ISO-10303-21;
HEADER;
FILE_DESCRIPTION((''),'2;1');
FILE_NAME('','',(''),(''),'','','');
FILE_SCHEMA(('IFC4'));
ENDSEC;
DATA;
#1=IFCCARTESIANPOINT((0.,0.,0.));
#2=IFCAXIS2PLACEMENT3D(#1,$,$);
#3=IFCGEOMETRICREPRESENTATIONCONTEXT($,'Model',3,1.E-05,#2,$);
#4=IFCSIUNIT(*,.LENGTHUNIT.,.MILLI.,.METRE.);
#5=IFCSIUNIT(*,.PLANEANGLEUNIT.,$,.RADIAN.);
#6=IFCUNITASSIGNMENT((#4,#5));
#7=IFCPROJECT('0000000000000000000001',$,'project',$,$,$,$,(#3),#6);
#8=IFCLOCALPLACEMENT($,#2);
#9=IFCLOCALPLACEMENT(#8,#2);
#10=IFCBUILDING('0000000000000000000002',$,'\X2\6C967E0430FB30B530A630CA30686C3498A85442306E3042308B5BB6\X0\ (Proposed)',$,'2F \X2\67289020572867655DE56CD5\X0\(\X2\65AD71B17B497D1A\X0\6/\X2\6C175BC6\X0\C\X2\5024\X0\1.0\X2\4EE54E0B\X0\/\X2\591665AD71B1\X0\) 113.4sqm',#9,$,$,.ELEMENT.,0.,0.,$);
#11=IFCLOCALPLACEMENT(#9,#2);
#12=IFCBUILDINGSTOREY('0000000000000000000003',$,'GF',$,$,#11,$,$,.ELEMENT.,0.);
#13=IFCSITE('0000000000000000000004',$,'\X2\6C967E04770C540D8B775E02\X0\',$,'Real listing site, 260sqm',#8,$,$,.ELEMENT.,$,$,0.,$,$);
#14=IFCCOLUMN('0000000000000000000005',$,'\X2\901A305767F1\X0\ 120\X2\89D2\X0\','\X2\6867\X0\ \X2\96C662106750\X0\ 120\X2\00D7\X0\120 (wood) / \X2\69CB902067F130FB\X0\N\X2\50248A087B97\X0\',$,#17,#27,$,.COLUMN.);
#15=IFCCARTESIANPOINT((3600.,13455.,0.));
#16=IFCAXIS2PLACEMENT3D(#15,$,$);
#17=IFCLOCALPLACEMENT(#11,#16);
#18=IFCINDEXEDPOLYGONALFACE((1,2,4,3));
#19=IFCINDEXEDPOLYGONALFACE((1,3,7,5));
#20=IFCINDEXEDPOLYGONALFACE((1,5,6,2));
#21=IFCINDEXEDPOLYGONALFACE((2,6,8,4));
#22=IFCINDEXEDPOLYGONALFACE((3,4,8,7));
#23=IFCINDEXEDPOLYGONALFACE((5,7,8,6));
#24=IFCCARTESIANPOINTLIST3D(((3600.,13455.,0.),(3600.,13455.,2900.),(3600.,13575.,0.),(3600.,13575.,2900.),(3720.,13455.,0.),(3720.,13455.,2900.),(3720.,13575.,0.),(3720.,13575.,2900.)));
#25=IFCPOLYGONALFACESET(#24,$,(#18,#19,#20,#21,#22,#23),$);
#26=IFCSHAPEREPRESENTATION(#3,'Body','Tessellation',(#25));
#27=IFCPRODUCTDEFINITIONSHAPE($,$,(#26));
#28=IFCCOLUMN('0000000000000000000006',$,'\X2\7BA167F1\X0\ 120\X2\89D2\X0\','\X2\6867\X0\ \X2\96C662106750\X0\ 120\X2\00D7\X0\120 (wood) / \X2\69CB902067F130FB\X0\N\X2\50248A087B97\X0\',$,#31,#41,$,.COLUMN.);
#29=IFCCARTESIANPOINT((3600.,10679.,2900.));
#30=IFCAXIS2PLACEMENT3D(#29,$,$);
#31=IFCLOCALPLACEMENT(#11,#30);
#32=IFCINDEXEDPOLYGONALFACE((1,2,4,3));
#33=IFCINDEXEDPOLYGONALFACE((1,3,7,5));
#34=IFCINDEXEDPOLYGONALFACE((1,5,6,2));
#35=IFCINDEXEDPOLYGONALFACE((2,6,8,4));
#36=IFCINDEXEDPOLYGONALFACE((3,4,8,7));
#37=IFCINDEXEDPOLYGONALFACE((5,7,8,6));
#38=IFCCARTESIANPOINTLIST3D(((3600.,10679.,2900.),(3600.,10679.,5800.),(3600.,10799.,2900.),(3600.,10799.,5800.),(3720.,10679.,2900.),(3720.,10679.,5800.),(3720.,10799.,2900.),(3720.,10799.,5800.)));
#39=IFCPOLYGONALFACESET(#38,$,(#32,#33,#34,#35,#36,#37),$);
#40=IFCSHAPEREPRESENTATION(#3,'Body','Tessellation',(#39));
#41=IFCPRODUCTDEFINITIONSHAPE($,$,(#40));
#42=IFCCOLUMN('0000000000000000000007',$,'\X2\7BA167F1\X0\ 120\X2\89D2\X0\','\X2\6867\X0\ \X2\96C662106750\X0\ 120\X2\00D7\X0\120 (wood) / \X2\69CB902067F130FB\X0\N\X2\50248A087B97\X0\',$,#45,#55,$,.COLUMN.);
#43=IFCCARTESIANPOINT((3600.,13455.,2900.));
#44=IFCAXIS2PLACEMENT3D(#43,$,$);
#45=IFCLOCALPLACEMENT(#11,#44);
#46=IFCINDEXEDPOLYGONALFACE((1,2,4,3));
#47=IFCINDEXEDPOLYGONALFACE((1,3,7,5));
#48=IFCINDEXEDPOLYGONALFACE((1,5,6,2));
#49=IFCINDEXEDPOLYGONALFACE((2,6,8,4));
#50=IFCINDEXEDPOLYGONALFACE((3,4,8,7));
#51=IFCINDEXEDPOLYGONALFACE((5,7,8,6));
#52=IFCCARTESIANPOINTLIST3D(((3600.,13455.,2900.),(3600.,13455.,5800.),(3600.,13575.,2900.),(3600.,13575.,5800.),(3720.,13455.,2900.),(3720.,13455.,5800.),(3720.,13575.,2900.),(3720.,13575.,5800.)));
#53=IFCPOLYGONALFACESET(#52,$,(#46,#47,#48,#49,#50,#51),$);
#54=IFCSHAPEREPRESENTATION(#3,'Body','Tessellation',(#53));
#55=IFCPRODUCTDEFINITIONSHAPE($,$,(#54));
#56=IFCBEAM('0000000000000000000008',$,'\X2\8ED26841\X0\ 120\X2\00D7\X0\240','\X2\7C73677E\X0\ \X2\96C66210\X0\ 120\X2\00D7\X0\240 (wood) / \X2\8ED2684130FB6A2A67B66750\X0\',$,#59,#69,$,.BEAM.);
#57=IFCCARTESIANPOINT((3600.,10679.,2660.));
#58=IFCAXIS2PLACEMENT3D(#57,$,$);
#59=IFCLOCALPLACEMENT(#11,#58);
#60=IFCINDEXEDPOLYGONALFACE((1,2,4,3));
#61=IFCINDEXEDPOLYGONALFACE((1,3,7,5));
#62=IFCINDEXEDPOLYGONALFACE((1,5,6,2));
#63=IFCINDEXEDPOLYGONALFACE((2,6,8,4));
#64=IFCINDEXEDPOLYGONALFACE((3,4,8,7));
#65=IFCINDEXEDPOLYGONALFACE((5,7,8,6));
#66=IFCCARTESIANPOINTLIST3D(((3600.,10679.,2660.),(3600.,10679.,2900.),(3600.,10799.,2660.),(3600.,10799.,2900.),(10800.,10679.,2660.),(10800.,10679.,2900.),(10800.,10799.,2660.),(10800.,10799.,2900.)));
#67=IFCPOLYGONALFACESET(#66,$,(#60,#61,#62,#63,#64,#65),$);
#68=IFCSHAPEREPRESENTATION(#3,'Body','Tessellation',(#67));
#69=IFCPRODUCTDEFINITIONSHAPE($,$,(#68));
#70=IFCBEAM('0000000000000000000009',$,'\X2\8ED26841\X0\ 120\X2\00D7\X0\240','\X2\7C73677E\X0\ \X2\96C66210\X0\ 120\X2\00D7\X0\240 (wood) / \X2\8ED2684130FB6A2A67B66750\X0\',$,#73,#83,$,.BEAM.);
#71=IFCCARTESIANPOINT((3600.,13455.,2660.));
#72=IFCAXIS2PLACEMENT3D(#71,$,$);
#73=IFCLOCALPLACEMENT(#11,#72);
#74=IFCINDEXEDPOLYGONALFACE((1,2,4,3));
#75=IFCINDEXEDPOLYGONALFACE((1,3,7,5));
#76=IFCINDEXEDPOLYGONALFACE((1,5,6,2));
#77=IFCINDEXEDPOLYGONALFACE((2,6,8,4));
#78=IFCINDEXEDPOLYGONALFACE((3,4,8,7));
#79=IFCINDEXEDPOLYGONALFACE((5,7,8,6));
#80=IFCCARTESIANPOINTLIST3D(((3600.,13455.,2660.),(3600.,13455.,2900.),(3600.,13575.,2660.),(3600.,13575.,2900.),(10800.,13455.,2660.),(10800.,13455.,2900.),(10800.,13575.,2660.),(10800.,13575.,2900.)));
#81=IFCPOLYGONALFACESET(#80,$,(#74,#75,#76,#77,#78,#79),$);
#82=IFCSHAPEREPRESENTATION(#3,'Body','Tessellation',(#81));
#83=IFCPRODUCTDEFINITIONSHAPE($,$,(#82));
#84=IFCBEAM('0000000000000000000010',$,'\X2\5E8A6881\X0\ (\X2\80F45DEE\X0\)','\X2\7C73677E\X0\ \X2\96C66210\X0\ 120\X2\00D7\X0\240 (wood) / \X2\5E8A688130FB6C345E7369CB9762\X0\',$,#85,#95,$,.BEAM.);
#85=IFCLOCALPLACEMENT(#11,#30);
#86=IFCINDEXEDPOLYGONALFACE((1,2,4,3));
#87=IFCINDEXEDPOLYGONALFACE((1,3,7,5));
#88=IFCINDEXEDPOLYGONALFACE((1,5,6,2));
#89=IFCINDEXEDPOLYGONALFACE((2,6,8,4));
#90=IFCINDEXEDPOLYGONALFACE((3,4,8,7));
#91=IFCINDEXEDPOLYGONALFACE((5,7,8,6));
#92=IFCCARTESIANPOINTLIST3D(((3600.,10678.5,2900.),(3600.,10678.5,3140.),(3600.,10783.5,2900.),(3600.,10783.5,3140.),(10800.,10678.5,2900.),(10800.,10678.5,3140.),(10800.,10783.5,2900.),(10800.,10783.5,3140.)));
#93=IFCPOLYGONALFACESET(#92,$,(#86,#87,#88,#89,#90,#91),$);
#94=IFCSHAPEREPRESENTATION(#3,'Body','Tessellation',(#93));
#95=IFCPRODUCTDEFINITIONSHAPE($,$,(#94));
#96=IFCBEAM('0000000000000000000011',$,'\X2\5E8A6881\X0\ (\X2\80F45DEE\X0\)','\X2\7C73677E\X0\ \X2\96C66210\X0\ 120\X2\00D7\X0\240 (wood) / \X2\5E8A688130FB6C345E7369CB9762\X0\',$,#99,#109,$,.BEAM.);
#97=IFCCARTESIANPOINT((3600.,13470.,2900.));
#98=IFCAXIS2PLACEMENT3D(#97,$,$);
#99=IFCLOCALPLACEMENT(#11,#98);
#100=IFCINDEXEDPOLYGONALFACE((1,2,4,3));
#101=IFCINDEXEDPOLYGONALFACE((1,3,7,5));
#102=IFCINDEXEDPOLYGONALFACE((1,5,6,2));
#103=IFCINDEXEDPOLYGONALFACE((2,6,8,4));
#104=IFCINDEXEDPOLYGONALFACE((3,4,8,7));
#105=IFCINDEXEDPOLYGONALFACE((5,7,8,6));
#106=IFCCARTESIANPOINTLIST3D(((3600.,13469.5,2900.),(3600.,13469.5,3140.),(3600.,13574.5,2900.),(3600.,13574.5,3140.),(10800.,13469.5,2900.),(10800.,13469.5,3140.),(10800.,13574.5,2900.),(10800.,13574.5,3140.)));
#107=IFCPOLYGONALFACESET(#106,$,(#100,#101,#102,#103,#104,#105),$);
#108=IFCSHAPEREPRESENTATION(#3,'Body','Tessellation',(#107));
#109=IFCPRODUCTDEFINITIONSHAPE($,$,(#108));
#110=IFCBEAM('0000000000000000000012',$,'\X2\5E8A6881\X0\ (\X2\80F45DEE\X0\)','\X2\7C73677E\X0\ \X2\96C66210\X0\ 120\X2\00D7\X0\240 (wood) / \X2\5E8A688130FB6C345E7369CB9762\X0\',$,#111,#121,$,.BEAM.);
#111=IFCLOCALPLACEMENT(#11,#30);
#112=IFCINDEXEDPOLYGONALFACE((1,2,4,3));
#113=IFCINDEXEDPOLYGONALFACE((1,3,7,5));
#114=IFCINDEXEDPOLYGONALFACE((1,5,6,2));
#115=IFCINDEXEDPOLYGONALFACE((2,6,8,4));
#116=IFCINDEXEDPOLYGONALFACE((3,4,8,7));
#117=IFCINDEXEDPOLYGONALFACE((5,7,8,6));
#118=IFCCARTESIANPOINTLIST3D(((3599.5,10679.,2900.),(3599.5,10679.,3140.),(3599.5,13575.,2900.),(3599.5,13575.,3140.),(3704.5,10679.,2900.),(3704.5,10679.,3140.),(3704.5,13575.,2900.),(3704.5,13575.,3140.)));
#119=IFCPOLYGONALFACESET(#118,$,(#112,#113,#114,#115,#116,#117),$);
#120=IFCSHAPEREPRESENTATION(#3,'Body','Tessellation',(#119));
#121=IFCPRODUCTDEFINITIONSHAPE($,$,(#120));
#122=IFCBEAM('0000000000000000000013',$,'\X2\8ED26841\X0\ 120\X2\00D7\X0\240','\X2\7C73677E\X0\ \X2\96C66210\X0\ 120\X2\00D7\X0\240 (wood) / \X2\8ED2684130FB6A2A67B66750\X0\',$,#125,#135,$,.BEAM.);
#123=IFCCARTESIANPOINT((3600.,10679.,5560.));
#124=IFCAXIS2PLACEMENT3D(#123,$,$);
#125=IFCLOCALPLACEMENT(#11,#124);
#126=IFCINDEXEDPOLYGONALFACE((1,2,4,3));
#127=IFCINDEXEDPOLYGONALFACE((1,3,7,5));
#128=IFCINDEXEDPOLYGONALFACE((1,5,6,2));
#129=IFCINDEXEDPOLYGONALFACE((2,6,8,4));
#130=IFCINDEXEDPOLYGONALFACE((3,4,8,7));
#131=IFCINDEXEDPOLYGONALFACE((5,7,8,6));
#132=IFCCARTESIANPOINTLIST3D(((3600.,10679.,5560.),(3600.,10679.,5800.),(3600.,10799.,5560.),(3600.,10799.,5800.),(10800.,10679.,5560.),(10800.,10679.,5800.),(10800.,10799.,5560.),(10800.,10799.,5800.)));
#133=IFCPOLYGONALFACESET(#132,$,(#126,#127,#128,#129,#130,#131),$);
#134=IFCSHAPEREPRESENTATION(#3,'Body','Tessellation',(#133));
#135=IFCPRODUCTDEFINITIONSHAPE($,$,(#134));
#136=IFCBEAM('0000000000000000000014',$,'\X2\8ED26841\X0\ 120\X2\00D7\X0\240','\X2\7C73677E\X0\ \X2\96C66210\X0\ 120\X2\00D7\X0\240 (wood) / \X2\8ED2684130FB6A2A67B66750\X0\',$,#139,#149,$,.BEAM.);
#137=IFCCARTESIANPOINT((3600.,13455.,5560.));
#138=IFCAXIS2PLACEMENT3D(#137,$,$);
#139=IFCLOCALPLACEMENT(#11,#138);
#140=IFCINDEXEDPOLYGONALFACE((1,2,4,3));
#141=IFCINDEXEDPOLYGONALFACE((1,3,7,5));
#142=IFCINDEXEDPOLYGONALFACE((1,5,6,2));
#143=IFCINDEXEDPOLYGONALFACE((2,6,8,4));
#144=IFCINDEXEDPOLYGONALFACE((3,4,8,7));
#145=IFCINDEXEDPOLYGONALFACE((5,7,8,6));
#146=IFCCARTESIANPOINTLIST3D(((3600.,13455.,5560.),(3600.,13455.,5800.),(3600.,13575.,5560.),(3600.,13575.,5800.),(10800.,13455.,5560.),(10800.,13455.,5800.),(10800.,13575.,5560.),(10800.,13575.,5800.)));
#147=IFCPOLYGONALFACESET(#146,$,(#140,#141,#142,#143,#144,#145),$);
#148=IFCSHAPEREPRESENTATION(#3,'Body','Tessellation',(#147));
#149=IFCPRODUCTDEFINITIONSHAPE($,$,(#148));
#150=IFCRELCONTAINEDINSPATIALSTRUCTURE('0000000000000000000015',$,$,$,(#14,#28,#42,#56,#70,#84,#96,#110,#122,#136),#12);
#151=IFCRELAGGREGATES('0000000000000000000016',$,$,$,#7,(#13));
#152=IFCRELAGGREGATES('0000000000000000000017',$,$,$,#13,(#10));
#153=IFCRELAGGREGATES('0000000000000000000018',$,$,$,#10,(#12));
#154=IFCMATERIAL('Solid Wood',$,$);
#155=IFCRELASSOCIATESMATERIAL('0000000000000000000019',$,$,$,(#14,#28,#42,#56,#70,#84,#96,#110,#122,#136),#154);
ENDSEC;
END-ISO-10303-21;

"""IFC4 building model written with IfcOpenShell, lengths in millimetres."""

from ifc_helpers import new_model, si_unit, frame, frame_2d, origin, place, context, project, spatial, rectangle, extrude, material, element, save


model = new_model("IFC4")

# Units and contexts
model_context = context("Model", 3, precision=1e-05, world=origin())
ifc_project = project(units=[si_unit("LENGTHUNIT", "METRE", prefix="MILLI"), si_unit("PLANEANGLEUNIT", "RADIAN")], contexts=[model_context])

# Site, building, storey
site_placement = place(None, origin())
site = spatial("IfcSite", under=ifc_project, at=site_placement, Name="沖縄県名護市", ObjectType="Real listing site, 260sqm", CompositionType="ELEMENT", RefElevation=0.0)
building_placement = place(site_placement, origin())
building = spatial("IfcBuilding", under=site, at=building_placement, Name="沖縄・サウナと水風呂のある家 (Proposed)", ObjectType="2F 木造在来工法(断熱等級6/気密C値1.0以下/外断熱) 113.4sqm", CompositionType="ELEMENT", ElevationOfRefHeight=0.0, ElevationOfTerrain=0.0)
storey_placement = place(building_placement, origin())
storey = spatial("IfcBuildingStorey", under=building, at=storey_placement, Name="GF", CompositionType="ELEMENT", Elevation=0.0)

# Columns
ifc_material_1 = material(Name="Solid Wood")
column_1_placement = place(storey_placement, frame((3600.0, 13455.0, 0.0)))
element("IfcColumn", 1, at=column_1_placement, inside=storey, material=ifc_material_1, Name="通し柱 120角", Description="桧 集成材 120×120 (wood) / 構造柱・N値計算", PredefinedType="COLUMN", context=model_context, shape_type="SweptSolid", body=[
    extrude(rectangle(XDim=120.0, YDim=120.0, at=frame_2d((60.0, 60.0))), frame((3600.0, 13455.0, 0.0)), (0.0, 0.0, 1.0), 2900.0),
])
column_2_placement = place(storey_placement, frame((3600.0, 10679.0, 2900.0)))
element("IfcColumn", 2, at=column_2_placement, inside=storey, material=ifc_material_1, Name="管柱 120角", Description="桧 集成材 120×120 (wood) / 構造柱・N値計算", PredefinedType="COLUMN", context=model_context, shape_type="SweptSolid", body=[
    extrude(rectangle(XDim=120.0, YDim=120.0, at=frame_2d((60.0, 60.0))), frame((3600.0, 10679.0, 2900.0)), (0.0, 0.0, 1.0), 2900.0),
])
column_3_placement = place(storey_placement, frame((3600.0, 13455.0, 2900.0)))
element("IfcColumn", 3, at=column_3_placement, inside=storey, material=ifc_material_1, Name="管柱 120角", Description="桧 集成材 120×120 (wood) / 構造柱・N値計算", PredefinedType="COLUMN", context=model_context, shape_type="SweptSolid", body=[
    extrude(rectangle(XDim=120.0, YDim=120.0, at=frame_2d((60.0, 60.0))), frame((3600.0, 13455.0, 2900.0)), (0.0, 0.0, 1.0), 2900.0),
])

# Beams
beam_1_placement = place(storey_placement, frame((3600.0, 10679.0, 2660.0)))
element("IfcBeam", 4, at=beam_1_placement, inside=storey, material=ifc_material_1, Name="軒桁 120×240", Description="米松 集成 120×240 (wood) / 軒桁・横架材", PredefinedType="BEAM", context=model_context, shape_type="SweptSolid", body=[
    extrude(rectangle(XDim=7200.0, YDim=120.0, at=frame_2d((3600.0, 60.0))), frame((3600.0, 10679.0, 2660.0)), (0.0, 0.0, 1.0), 240.0),
])
beam_2_placement = place(storey_placement, frame((3600.0, 13455.0, 2660.0)))
element("IfcBeam", 5, at=beam_2_placement, inside=storey, material=ifc_material_1, Name="軒桁 120×240", Description="米松 集成 120×240 (wood) / 軒桁・横架材", PredefinedType="BEAM", context=model_context, shape_type="SweptSolid", body=[
    extrude(rectangle(XDim=7200.0, YDim=120.0, at=frame_2d((3600.0, 60.0))), frame((3600.0, 13455.0, 2660.0)), (0.0, 0.0, 1.0), 240.0),
])
beam_3_placement = place(storey_placement, frame((3600.0, 10679.0, 2900.0)))
element("IfcBeam", 6, at=beam_3_placement, inside=storey, material=ifc_material_1, Name="床梁 (胴差)", Description="米松 集成 120×240 (wood) / 床梁・水平構面", PredefinedType="BEAM", context=model_context, shape_type="SweptSolid", body=[
    extrude(rectangle(XDim=7200.0, YDim=105.0, at=frame_2d((3600.0, 52.0))), frame((3600.0, 10679.0, 2900.0)), (0.0, 0.0, 1.0), 240.0),
])
beam_4_placement = place(storey_placement, frame((3600.0, 13470.0, 2900.0)))
element("IfcBeam", 7, at=beam_4_placement, inside=storey, material=ifc_material_1, Name="床梁 (胴差)", Description="米松 集成 120×240 (wood) / 床梁・水平構面", PredefinedType="BEAM", context=model_context, shape_type="SweptSolid", body=[
    extrude(rectangle(XDim=7200.0, YDim=105.0, at=frame_2d((3600.0, 52.0))), frame((3600.0, 13470.0, 2900.0)), (0.0, 0.0, 1.0), 240.0),
])
beam_5_placement = place(storey_placement, frame((3600.0, 10679.0, 2900.0)))
element("IfcBeam", 8, at=beam_5_placement, inside=storey, material=ifc_material_1, Name="床梁 (胴差)", Description="米松 集成 120×240 (wood) / 床梁・水平構面", PredefinedType="BEAM", context=model_context, shape_type="SweptSolid", body=[
    extrude(rectangle(XDim=105.0, YDim=2896.0, at=frame_2d((52.0, 1448.0))), frame((3600.0, 10679.0, 2900.0)), (0.0, 0.0, 1.0), 240.0),
])
beam_6_placement = place(storey_placement, frame((3600.0, 10679.0, 5560.0)))
element("IfcBeam", 9, at=beam_6_placement, inside=storey, material=ifc_material_1, Name="軒桁 120×240", Description="米松 集成 120×240 (wood) / 軒桁・横架材", PredefinedType="BEAM", context=model_context, shape_type="SweptSolid", body=[
    extrude(rectangle(XDim=7200.0, YDim=120.0, at=frame_2d((3600.0, 60.0))), frame((3600.0, 10679.0, 5560.0)), (0.0, 0.0, 1.0), 240.0),
])
beam_7_placement = place(storey_placement, frame((3600.0, 13455.0, 5560.0)))
element("IfcBeam", 10, at=beam_7_placement, inside=storey, material=ifc_material_1, Name="軒桁 120×240", Description="米松 集成 120×240 (wood) / 軒桁・横架材", PredefinedType="BEAM", context=model_context, shape_type="SweptSolid", body=[
    extrude(rectangle(XDim=7200.0, YDim=120.0, at=frame_2d((3600.0, 60.0))), frame((3600.0, 13455.0, 5560.0)), (0.0, 0.0, 1.0), 240.0),
])

save(model, "model.ifc")
